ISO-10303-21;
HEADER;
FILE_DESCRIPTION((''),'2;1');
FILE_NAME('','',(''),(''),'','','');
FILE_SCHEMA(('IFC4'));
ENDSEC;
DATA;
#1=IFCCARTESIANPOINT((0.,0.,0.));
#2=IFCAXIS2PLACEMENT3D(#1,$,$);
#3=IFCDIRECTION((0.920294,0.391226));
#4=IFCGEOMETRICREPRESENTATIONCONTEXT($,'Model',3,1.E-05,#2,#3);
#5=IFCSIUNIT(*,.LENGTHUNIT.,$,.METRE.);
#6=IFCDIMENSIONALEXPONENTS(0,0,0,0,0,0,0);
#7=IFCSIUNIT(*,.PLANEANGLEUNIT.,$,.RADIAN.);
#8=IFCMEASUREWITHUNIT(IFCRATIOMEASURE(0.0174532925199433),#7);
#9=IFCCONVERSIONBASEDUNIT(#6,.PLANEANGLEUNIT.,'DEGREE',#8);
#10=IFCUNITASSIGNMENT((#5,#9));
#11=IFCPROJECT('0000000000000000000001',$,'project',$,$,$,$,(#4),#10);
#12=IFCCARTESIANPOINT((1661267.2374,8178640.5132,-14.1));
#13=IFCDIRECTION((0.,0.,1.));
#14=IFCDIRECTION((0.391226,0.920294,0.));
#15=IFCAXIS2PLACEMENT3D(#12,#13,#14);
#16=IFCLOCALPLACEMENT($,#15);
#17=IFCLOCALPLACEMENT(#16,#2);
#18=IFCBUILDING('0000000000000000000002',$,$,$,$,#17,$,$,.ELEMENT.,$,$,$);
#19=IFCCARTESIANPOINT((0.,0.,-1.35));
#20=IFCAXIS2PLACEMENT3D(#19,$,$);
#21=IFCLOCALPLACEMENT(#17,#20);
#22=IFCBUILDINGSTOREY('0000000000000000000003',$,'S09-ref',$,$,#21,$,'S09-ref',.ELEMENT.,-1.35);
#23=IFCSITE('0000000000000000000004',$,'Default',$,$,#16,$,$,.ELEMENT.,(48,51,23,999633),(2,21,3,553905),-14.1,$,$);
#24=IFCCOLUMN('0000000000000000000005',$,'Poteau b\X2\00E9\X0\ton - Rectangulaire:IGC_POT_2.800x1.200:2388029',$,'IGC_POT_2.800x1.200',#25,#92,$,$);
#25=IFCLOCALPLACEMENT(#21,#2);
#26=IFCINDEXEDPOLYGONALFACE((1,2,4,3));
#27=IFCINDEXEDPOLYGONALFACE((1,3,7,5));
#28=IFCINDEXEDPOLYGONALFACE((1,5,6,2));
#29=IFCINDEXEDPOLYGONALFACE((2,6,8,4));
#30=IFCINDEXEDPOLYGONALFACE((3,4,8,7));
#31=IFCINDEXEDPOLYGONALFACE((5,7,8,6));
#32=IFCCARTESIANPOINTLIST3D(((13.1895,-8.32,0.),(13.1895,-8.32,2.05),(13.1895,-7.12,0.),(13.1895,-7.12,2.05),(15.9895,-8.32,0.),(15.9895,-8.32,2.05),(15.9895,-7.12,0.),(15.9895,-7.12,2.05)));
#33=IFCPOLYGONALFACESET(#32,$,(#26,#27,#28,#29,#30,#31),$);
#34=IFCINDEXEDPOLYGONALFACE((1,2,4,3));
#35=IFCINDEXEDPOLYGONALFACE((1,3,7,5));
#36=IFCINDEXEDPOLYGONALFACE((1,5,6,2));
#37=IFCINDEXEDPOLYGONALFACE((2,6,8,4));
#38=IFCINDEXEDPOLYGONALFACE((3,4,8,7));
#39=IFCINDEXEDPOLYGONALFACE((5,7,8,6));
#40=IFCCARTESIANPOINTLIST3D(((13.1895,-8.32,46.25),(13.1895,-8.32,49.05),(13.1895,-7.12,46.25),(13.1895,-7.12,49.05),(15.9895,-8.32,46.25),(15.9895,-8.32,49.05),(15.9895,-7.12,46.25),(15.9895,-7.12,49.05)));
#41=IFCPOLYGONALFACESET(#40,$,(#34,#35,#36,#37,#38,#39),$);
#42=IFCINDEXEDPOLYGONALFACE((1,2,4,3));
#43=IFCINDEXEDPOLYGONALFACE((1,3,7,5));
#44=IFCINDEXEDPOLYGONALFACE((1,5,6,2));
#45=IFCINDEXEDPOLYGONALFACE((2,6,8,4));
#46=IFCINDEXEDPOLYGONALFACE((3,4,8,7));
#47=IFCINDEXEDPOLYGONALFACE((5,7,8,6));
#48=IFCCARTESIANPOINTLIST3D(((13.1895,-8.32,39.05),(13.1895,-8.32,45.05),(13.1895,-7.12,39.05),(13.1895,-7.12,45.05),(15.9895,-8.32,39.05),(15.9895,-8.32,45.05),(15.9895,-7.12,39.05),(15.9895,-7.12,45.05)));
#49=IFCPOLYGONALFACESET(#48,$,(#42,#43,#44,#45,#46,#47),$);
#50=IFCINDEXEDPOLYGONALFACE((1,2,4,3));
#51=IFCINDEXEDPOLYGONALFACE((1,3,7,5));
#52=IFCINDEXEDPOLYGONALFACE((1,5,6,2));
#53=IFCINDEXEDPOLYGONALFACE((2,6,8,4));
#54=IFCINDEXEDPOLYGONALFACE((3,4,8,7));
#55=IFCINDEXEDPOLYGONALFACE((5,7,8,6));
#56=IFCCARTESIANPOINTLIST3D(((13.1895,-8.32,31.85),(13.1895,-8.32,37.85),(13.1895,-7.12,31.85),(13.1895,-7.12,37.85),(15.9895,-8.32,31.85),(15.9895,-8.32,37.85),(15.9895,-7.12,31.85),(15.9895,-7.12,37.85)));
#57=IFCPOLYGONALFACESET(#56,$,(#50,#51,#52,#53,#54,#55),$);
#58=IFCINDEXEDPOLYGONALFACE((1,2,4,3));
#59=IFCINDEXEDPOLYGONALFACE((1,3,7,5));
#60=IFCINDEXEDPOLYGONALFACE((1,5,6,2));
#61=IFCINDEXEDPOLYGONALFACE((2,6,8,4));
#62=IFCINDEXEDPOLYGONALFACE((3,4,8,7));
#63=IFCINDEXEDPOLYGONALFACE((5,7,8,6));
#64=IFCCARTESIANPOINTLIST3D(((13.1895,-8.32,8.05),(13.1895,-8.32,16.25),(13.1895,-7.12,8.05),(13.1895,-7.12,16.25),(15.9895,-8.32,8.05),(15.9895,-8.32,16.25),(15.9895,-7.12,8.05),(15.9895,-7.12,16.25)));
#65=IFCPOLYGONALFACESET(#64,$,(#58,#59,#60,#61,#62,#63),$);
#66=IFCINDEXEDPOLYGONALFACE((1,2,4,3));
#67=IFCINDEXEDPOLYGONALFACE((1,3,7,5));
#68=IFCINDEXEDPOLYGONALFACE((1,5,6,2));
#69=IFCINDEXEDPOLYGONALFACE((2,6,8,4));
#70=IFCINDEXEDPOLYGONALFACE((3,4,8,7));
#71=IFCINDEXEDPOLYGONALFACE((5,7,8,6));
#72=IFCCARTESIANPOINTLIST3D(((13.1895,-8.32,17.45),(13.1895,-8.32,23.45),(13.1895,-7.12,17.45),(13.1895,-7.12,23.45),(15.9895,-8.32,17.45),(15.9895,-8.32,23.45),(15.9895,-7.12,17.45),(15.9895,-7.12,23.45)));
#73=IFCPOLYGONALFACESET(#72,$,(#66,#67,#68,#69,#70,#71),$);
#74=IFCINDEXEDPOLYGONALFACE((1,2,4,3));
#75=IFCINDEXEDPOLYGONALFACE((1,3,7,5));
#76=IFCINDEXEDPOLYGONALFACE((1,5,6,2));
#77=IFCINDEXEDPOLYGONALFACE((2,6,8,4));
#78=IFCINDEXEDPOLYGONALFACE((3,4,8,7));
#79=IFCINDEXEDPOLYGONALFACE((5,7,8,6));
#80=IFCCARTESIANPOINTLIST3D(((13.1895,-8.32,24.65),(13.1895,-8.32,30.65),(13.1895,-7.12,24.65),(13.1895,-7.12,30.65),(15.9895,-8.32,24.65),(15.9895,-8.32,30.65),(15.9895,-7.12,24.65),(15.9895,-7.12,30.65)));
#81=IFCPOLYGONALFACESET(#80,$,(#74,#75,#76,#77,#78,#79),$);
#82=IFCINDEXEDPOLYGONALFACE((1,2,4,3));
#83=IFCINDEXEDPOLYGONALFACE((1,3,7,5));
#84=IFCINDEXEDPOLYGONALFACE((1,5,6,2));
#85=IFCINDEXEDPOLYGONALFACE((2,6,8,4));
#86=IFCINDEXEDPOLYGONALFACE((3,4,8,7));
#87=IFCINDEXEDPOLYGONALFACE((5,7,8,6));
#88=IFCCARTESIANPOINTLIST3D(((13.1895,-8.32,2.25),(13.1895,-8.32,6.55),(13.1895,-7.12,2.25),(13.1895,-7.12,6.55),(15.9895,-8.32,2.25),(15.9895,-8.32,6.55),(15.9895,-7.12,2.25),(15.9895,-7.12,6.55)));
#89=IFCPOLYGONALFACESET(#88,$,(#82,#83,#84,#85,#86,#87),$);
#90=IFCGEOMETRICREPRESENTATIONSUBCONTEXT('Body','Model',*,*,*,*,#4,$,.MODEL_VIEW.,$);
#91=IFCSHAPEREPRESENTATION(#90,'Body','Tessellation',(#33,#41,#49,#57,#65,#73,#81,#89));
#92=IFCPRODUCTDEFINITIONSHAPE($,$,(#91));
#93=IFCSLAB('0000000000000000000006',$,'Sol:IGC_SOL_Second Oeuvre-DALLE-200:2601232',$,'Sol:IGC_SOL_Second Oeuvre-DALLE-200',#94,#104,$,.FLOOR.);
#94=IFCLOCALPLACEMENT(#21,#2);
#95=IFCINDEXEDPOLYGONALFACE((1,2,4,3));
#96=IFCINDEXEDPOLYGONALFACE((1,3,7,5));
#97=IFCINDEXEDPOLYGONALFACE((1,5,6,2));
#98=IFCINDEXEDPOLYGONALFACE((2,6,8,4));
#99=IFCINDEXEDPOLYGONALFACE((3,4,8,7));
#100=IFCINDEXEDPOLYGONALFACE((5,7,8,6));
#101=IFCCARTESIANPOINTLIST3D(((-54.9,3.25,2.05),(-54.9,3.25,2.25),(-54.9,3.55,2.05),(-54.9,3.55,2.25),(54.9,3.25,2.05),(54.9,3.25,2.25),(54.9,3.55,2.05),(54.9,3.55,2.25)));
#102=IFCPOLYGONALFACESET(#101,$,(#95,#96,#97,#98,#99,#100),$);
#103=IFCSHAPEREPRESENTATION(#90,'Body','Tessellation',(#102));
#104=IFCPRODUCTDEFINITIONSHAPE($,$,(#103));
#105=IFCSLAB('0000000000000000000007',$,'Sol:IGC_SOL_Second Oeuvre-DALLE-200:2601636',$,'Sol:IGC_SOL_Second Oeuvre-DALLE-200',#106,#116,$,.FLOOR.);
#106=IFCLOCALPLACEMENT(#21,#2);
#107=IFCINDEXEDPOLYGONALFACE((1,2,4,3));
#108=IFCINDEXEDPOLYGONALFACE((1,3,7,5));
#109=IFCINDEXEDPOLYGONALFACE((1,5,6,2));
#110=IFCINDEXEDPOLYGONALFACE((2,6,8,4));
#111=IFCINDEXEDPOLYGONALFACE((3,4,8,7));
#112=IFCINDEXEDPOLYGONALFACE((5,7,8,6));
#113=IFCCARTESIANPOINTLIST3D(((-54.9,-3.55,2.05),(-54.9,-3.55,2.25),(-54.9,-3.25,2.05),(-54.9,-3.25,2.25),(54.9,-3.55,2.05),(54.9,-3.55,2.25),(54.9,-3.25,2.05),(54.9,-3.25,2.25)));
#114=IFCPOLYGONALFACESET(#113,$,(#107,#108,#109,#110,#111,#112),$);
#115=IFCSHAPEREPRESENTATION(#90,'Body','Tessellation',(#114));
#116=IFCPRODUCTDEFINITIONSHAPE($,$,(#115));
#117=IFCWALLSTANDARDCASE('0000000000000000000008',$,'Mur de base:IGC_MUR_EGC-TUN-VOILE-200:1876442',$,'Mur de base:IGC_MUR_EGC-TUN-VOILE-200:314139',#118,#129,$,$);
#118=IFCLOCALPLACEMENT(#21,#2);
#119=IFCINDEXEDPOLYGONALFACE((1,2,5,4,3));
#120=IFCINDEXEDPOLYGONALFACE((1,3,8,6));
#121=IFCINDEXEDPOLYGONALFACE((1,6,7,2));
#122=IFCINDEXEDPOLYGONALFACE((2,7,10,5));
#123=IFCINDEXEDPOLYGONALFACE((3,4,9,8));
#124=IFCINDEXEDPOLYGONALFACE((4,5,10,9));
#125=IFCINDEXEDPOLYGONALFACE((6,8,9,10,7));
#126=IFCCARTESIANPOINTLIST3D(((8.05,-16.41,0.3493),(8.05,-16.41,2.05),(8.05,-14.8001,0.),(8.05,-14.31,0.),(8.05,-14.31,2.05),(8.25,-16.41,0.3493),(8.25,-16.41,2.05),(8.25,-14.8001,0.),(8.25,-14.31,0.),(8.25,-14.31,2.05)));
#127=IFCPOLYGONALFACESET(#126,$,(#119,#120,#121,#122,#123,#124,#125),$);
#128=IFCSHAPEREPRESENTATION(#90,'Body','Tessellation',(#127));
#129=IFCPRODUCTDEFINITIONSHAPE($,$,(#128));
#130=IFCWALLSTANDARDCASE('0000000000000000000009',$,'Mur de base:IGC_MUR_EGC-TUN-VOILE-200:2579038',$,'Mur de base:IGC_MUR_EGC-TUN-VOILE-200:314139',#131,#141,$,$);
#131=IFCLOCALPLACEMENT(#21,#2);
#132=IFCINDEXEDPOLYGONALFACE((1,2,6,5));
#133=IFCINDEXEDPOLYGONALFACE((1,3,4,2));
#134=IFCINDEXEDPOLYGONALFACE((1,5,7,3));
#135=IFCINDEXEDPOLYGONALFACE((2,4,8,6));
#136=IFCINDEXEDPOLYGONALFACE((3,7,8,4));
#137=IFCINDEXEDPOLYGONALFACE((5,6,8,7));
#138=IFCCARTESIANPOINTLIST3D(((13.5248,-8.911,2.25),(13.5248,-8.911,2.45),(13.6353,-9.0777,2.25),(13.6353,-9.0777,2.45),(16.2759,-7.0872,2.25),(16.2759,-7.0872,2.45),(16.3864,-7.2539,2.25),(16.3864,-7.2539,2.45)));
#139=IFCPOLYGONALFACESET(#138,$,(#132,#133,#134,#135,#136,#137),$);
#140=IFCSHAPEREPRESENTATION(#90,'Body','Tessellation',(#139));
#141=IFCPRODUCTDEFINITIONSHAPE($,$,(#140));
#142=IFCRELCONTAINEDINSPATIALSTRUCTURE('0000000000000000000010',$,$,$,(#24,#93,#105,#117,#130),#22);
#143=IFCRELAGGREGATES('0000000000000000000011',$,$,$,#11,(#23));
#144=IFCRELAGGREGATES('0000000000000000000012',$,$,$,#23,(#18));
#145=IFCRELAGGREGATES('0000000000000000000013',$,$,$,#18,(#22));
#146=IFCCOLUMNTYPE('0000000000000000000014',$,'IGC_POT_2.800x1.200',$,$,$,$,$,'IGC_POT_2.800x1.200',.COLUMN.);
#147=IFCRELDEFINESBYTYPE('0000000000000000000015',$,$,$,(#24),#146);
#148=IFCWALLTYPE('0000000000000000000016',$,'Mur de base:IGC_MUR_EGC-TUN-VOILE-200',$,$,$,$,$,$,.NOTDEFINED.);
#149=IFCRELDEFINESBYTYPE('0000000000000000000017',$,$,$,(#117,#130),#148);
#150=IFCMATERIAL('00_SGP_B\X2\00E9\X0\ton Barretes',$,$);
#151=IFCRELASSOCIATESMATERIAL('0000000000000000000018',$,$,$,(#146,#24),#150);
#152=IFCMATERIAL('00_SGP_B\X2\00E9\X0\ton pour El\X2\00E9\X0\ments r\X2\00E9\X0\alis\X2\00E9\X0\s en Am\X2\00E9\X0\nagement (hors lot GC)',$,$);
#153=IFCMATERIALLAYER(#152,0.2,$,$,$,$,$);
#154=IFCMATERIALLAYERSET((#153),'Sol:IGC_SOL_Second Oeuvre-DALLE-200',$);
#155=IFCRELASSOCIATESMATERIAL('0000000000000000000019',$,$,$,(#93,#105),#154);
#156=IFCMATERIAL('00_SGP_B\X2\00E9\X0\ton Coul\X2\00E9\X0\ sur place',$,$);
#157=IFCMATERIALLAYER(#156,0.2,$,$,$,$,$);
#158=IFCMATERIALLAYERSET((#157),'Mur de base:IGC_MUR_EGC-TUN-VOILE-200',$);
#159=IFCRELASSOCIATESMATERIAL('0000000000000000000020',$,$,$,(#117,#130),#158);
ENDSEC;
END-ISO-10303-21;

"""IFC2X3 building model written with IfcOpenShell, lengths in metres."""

from ifc_helpers import new_model, entity, si_unit, converted_unit, direction, frame, frame_2d, origin, place, context, subcontext, project, spatial, polyline, rectangle, extrude, clip, bounded_halfspace, source, transform, mapped, material, layer, layer_set, layer_usage, type_object, type_shapes, element, save


model = new_model("IFC2X3")

# Units and contexts
model_context = context("Model", 3, precision=1e-05, world=origin(), true_north=direction((0.920294, 0.391226)))
body_context = subcontext(model_context, "Body", "Model", "MODEL_VIEW")
ifc_project = project(units=[si_unit("LENGTHUNIT", "METRE"), converted_unit("PLANEANGLEUNIT", "DEGREE", entity("IfcRatioMeasure", 0.0174532925199433), si_unit("PLANEANGLEUNIT", "RADIAN"), dimensions=[0, 0, 0, 0, 0, 0, 0])], contexts=[model_context])

# Site, building, storey
site_placement = place(None, frame((1661267.2374, 8178640.5132, -14.1), z_axis=(0.0, 0.0, 1.0), x_axis=(0.391226, 0.920294, 0.0)))
site = spatial("IfcSite", under=ifc_project, at=site_placement, Name="Default", CompositionType="ELEMENT", RefLatitude=(48, 51, 23, 999633), RefLongitude=(2, 21, 3, 553905), RefElevation=-14.1)
building_placement = place(site_placement, origin())
building = spatial("IfcBuilding", under=site, at=building_placement, CompositionType="ELEMENT")
storey_placement = place(building_placement, frame((0.0, 0.0, -1.35)))
storey = spatial("IfcBuildingStorey", under=building, at=storey_placement, Name="S09-ref", LongName="S09-ref", CompositionType="ELEMENT", Elevation=-1.35)

# Column
ifc_material_1 = material(Name="00_SGP_Béton Barretes")
column_type_1 = type_object("IfcColumnType", Name="IGC_POT_2.800x1.200", ElementType="IGC_POT_2.800x1.200", PredefinedType="COLUMN", material=ifc_material_1)
shared_shape_1 = source(origin(), body_context, "Body", "SweptSolid", [
    extrude(rectangle(XDim=1.2, YDim=2.8, at=frame_2d((0.0, 0.0), x_axis=(1.0, 0.0))), frame((14.5895, -7.72, -1.35), z_axis=(0.0, 0.0, 1.0), x_axis=(0.0, -1.0, 0.0)), (0.0, 0.0, 1.0), 2.05),
    extrude(rectangle(XDim=1.2, YDim=2.8, at=frame_2d((0.0, 0.0), x_axis=(1.0, 0.0))), frame((14.5895, -7.72, 44.9), z_axis=(0.0, 0.0, 1.0), x_axis=(0.0, -1.0, 0.0)), (0.0, 0.0, 1.0), 2.8),
    extrude(rectangle(XDim=1.2, YDim=2.8, at=frame_2d((0.0, 0.0), x_axis=(1.0, 0.0))), frame((14.5895, -7.72, 37.7), z_axis=(0.0, 0.0, 1.0), x_axis=(0.0, -1.0, 0.0)), (0.0, 0.0, 1.0), 6.0),
    extrude(rectangle(XDim=1.2, YDim=2.8, at=frame_2d((0.0, 0.0), x_axis=(1.0, 0.0))), frame((14.5895, -7.72, 30.5), z_axis=(0.0, 0.0, 1.0), x_axis=(0.0, -1.0, 0.0)), (0.0, 0.0, 1.0), 6.0),
    extrude(rectangle(XDim=1.2, YDim=2.8, at=frame_2d((0.0, 0.0), x_axis=(1.0, 0.0))), frame((14.5895, -7.72, 6.7), z_axis=(0.0, 0.0, 1.0), x_axis=(0.0, -1.0, 0.0)), (0.0, 0.0, 1.0), 8.2),
    extrude(rectangle(XDim=1.2, YDim=2.8, at=frame_2d((0.0, 0.0), x_axis=(1.0, 0.0))), frame((14.5895, -7.72, 16.1), z_axis=(0.0, 0.0, 1.0), x_axis=(0.0, -1.0, 0.0)), (0.0, 0.0, 1.0), 6.0),
    extrude(rectangle(XDim=1.2, YDim=2.8, at=frame_2d((0.0, 0.0), x_axis=(1.0, 0.0))), frame((14.5895, -7.72, 23.3), z_axis=(0.0, 0.0, 1.0), x_axis=(0.0, -1.0, 0.0)), (0.0, 0.0, 1.0), 6.0),
    extrude(rectangle(XDim=1.2, YDim=2.8, at=frame_2d((0.0, 0.0), x_axis=(1.0, 0.0))), frame((14.5895, -7.72, 0.9), z_axis=(0.0, 0.0, 1.0), x_axis=(0.0, -1.0, 0.0)), (0.0, 0.0, 1.0), 4.3),
])
type_shapes(column_type_1, [shared_shape_1])
column_1_placement = place(storey_placement, frame((0.0, 0.0, 1.35)))
element("IfcColumn", 1, at=column_1_placement, inside=storey, type_object=column_type_1, material=ifc_material_1, Name="Poteau béton - Rectangulaire:IGC_POT_2.800x1.200:2388029", ObjectType="IGC_POT_2.800x1.200", context=body_context, shape_type="MappedRepresentation", body=[
    mapped(shared_shape_1, transform((0.0, 0.0, 0.0), scale=1.0)),
])

# Slabs
ifc_material_2 = material(Name="00_SGP_Béton pour Eléments réalisés en Aménagement (hors lot GC)")
ifc_layer_1 = layer(ifc_material_2, 0.2)
ifc_layer_set_1 = layer_set([ifc_layer_1], Name="Sol:IGC_SOL_Second Oeuvre-DALLE-200")
ifc_layer_usage_1 = layer_usage(ifc_layer_set_1, "AXIS3", "POSITIVE", 0.0)
slab_1_placement = place(storey_placement, origin())
element("IfcSlab", 2, at=slab_1_placement, inside=storey, material=ifc_layer_usage_1, Name="Sol:IGC_SOL_Second Oeuvre-DALLE-200:2601232", ObjectType="Sol:IGC_SOL_Second Oeuvre-DALLE-200", PredefinedType="FLOOR", context=body_context, shape_type="SweptSolid", body=[
    extrude(rectangle(XDim=0.3, YDim=109.8, at=frame_2d((0.0, 0.0), x_axis=(1.0, 0.0))), frame((0.0, 3.4, 2.25), z_axis=(0.0, 0.0, -1.0), x_axis=(0.0, 1.0, 0.0)), (0.0, 0.0, 1.0), 0.2),
])
ifc_layer_usage_2 = layer_usage(ifc_layer_set_1, "AXIS3", "POSITIVE", 0.0)
slab_2_placement = place(storey_placement, origin())
element("IfcSlab", 3, at=slab_2_placement, inside=storey, material=ifc_layer_usage_2, Name="Sol:IGC_SOL_Second Oeuvre-DALLE-200:2601636", ObjectType="Sol:IGC_SOL_Second Oeuvre-DALLE-200", PredefinedType="FLOOR", context=body_context, shape_type="SweptSolid", body=[
    extrude(rectangle(XDim=0.3, YDim=109.8, at=frame_2d((0.0, 0.0), x_axis=(1.0, 0.0))), frame((0.0, -3.4, 2.25), z_axis=(0.0, 0.0, -1.0), x_axis=(0.0, 1.0, 0.0)), (0.0, 0.0, 1.0), 0.2),
])
ifc_material_3 = material(Name="00_SGP_Béton Coulé sur place")

# Shared definitions
ifc_layer_2 = layer(ifc_material_3, 0.2)
ifc_layer_set_2 = layer_set([ifc_layer_2], Name="Mur de base:IGC_MUR_EGC-TUN-VOILE-200")
wall_type = type_object("IfcWallType", Name="Mur de base:IGC_MUR_EGC-TUN-VOILE-200", PredefinedType="NOTDEFINED")

# Walls
ifc_layer_usage_3 = layer_usage(ifc_layer_set_2, "AXIS2", "POSITIVE", -0.1)
wall_1_placement = place(storey_placement, frame((8.15, -16.41, 0.0), z_axis=(0.0, 0.0, 1.0), x_axis=(0.0, 1.0, 0.0)))
element("IfcWallStandardCase", 4, at=wall_1_placement, inside=storey, type_object=wall_type, material=ifc_layer_usage_3, Name="Mur de base:IGC_MUR_EGC-TUN-VOILE-200:1876442", ObjectType="Mur de base:IGC_MUR_EGC-TUN-VOILE-200:314139", context=body_context, shape_type="Clipping", body=[
    clip(clip(extrude(rectangle(XDim=2.1, YDim=0.2, at=frame_2d((1.05, 0.0), x_axis=(-1.0, 0.0))), origin(), (0.0, 0.0, 1.0), 2.05), bounded_halfspace(frame((0.0, -0.1, 2.05), z_axis=(0.0, 0.0, -1.0), x_axis=(0.0, 1.0, 0.0)), True, frame((0.0, -0.1, 2.05)), polyline([(0.0, 0.0), (2.1, 0.0), (2.1, 0.2), (0.0, 0.2), (0.0, 0.0)]))), bounded_halfspace(frame((1.6098, -0.1, 0.0), z_axis=(0.21204, 0.0, 0.977261), x_axis=(0.0, 1.0, 0.0)), True, frame((1.6098, -0.1, 0.0), z_axis=(0.21204, 0.0, 0.977261), x_axis=(0.0, 1.0, 0.0)), polyline([(0.0, 0.0), (0.2, 0.0), (0.2, 1.6473), (0.0, 1.6473), (0.0, 0.0)]))),
])
ifc_layer_usage_4 = layer_usage(ifc_layer_set_2, "AXIS2", "NEGATIVE", 0.1)
wall_2_placement = place(storey_placement, frame((13.5801, -8.9943, 2.25), z_axis=(0.0, 0.0, 1.0), x_axis=(0.833489, 0.552537, 0.0)))
element("IfcWallStandardCase", 5, at=wall_2_placement, inside=storey, type_object=wall_type, material=ifc_layer_usage_4, Name="Mur de base:IGC_MUR_EGC-TUN-VOILE-200:2579038", ObjectType="Mur de base:IGC_MUR_EGC-TUN-VOILE-200:314139", context=body_context, shape_type="SweptSolid", body=[
    extrude(rectangle(XDim=3.3006, YDim=0.2, at=frame_2d((1.6503, 0.0), x_axis=(-1.0, 0.0))), origin(), (0.0, 0.0, 1.0), 0.2),
])

save(model, "model.ifc")
